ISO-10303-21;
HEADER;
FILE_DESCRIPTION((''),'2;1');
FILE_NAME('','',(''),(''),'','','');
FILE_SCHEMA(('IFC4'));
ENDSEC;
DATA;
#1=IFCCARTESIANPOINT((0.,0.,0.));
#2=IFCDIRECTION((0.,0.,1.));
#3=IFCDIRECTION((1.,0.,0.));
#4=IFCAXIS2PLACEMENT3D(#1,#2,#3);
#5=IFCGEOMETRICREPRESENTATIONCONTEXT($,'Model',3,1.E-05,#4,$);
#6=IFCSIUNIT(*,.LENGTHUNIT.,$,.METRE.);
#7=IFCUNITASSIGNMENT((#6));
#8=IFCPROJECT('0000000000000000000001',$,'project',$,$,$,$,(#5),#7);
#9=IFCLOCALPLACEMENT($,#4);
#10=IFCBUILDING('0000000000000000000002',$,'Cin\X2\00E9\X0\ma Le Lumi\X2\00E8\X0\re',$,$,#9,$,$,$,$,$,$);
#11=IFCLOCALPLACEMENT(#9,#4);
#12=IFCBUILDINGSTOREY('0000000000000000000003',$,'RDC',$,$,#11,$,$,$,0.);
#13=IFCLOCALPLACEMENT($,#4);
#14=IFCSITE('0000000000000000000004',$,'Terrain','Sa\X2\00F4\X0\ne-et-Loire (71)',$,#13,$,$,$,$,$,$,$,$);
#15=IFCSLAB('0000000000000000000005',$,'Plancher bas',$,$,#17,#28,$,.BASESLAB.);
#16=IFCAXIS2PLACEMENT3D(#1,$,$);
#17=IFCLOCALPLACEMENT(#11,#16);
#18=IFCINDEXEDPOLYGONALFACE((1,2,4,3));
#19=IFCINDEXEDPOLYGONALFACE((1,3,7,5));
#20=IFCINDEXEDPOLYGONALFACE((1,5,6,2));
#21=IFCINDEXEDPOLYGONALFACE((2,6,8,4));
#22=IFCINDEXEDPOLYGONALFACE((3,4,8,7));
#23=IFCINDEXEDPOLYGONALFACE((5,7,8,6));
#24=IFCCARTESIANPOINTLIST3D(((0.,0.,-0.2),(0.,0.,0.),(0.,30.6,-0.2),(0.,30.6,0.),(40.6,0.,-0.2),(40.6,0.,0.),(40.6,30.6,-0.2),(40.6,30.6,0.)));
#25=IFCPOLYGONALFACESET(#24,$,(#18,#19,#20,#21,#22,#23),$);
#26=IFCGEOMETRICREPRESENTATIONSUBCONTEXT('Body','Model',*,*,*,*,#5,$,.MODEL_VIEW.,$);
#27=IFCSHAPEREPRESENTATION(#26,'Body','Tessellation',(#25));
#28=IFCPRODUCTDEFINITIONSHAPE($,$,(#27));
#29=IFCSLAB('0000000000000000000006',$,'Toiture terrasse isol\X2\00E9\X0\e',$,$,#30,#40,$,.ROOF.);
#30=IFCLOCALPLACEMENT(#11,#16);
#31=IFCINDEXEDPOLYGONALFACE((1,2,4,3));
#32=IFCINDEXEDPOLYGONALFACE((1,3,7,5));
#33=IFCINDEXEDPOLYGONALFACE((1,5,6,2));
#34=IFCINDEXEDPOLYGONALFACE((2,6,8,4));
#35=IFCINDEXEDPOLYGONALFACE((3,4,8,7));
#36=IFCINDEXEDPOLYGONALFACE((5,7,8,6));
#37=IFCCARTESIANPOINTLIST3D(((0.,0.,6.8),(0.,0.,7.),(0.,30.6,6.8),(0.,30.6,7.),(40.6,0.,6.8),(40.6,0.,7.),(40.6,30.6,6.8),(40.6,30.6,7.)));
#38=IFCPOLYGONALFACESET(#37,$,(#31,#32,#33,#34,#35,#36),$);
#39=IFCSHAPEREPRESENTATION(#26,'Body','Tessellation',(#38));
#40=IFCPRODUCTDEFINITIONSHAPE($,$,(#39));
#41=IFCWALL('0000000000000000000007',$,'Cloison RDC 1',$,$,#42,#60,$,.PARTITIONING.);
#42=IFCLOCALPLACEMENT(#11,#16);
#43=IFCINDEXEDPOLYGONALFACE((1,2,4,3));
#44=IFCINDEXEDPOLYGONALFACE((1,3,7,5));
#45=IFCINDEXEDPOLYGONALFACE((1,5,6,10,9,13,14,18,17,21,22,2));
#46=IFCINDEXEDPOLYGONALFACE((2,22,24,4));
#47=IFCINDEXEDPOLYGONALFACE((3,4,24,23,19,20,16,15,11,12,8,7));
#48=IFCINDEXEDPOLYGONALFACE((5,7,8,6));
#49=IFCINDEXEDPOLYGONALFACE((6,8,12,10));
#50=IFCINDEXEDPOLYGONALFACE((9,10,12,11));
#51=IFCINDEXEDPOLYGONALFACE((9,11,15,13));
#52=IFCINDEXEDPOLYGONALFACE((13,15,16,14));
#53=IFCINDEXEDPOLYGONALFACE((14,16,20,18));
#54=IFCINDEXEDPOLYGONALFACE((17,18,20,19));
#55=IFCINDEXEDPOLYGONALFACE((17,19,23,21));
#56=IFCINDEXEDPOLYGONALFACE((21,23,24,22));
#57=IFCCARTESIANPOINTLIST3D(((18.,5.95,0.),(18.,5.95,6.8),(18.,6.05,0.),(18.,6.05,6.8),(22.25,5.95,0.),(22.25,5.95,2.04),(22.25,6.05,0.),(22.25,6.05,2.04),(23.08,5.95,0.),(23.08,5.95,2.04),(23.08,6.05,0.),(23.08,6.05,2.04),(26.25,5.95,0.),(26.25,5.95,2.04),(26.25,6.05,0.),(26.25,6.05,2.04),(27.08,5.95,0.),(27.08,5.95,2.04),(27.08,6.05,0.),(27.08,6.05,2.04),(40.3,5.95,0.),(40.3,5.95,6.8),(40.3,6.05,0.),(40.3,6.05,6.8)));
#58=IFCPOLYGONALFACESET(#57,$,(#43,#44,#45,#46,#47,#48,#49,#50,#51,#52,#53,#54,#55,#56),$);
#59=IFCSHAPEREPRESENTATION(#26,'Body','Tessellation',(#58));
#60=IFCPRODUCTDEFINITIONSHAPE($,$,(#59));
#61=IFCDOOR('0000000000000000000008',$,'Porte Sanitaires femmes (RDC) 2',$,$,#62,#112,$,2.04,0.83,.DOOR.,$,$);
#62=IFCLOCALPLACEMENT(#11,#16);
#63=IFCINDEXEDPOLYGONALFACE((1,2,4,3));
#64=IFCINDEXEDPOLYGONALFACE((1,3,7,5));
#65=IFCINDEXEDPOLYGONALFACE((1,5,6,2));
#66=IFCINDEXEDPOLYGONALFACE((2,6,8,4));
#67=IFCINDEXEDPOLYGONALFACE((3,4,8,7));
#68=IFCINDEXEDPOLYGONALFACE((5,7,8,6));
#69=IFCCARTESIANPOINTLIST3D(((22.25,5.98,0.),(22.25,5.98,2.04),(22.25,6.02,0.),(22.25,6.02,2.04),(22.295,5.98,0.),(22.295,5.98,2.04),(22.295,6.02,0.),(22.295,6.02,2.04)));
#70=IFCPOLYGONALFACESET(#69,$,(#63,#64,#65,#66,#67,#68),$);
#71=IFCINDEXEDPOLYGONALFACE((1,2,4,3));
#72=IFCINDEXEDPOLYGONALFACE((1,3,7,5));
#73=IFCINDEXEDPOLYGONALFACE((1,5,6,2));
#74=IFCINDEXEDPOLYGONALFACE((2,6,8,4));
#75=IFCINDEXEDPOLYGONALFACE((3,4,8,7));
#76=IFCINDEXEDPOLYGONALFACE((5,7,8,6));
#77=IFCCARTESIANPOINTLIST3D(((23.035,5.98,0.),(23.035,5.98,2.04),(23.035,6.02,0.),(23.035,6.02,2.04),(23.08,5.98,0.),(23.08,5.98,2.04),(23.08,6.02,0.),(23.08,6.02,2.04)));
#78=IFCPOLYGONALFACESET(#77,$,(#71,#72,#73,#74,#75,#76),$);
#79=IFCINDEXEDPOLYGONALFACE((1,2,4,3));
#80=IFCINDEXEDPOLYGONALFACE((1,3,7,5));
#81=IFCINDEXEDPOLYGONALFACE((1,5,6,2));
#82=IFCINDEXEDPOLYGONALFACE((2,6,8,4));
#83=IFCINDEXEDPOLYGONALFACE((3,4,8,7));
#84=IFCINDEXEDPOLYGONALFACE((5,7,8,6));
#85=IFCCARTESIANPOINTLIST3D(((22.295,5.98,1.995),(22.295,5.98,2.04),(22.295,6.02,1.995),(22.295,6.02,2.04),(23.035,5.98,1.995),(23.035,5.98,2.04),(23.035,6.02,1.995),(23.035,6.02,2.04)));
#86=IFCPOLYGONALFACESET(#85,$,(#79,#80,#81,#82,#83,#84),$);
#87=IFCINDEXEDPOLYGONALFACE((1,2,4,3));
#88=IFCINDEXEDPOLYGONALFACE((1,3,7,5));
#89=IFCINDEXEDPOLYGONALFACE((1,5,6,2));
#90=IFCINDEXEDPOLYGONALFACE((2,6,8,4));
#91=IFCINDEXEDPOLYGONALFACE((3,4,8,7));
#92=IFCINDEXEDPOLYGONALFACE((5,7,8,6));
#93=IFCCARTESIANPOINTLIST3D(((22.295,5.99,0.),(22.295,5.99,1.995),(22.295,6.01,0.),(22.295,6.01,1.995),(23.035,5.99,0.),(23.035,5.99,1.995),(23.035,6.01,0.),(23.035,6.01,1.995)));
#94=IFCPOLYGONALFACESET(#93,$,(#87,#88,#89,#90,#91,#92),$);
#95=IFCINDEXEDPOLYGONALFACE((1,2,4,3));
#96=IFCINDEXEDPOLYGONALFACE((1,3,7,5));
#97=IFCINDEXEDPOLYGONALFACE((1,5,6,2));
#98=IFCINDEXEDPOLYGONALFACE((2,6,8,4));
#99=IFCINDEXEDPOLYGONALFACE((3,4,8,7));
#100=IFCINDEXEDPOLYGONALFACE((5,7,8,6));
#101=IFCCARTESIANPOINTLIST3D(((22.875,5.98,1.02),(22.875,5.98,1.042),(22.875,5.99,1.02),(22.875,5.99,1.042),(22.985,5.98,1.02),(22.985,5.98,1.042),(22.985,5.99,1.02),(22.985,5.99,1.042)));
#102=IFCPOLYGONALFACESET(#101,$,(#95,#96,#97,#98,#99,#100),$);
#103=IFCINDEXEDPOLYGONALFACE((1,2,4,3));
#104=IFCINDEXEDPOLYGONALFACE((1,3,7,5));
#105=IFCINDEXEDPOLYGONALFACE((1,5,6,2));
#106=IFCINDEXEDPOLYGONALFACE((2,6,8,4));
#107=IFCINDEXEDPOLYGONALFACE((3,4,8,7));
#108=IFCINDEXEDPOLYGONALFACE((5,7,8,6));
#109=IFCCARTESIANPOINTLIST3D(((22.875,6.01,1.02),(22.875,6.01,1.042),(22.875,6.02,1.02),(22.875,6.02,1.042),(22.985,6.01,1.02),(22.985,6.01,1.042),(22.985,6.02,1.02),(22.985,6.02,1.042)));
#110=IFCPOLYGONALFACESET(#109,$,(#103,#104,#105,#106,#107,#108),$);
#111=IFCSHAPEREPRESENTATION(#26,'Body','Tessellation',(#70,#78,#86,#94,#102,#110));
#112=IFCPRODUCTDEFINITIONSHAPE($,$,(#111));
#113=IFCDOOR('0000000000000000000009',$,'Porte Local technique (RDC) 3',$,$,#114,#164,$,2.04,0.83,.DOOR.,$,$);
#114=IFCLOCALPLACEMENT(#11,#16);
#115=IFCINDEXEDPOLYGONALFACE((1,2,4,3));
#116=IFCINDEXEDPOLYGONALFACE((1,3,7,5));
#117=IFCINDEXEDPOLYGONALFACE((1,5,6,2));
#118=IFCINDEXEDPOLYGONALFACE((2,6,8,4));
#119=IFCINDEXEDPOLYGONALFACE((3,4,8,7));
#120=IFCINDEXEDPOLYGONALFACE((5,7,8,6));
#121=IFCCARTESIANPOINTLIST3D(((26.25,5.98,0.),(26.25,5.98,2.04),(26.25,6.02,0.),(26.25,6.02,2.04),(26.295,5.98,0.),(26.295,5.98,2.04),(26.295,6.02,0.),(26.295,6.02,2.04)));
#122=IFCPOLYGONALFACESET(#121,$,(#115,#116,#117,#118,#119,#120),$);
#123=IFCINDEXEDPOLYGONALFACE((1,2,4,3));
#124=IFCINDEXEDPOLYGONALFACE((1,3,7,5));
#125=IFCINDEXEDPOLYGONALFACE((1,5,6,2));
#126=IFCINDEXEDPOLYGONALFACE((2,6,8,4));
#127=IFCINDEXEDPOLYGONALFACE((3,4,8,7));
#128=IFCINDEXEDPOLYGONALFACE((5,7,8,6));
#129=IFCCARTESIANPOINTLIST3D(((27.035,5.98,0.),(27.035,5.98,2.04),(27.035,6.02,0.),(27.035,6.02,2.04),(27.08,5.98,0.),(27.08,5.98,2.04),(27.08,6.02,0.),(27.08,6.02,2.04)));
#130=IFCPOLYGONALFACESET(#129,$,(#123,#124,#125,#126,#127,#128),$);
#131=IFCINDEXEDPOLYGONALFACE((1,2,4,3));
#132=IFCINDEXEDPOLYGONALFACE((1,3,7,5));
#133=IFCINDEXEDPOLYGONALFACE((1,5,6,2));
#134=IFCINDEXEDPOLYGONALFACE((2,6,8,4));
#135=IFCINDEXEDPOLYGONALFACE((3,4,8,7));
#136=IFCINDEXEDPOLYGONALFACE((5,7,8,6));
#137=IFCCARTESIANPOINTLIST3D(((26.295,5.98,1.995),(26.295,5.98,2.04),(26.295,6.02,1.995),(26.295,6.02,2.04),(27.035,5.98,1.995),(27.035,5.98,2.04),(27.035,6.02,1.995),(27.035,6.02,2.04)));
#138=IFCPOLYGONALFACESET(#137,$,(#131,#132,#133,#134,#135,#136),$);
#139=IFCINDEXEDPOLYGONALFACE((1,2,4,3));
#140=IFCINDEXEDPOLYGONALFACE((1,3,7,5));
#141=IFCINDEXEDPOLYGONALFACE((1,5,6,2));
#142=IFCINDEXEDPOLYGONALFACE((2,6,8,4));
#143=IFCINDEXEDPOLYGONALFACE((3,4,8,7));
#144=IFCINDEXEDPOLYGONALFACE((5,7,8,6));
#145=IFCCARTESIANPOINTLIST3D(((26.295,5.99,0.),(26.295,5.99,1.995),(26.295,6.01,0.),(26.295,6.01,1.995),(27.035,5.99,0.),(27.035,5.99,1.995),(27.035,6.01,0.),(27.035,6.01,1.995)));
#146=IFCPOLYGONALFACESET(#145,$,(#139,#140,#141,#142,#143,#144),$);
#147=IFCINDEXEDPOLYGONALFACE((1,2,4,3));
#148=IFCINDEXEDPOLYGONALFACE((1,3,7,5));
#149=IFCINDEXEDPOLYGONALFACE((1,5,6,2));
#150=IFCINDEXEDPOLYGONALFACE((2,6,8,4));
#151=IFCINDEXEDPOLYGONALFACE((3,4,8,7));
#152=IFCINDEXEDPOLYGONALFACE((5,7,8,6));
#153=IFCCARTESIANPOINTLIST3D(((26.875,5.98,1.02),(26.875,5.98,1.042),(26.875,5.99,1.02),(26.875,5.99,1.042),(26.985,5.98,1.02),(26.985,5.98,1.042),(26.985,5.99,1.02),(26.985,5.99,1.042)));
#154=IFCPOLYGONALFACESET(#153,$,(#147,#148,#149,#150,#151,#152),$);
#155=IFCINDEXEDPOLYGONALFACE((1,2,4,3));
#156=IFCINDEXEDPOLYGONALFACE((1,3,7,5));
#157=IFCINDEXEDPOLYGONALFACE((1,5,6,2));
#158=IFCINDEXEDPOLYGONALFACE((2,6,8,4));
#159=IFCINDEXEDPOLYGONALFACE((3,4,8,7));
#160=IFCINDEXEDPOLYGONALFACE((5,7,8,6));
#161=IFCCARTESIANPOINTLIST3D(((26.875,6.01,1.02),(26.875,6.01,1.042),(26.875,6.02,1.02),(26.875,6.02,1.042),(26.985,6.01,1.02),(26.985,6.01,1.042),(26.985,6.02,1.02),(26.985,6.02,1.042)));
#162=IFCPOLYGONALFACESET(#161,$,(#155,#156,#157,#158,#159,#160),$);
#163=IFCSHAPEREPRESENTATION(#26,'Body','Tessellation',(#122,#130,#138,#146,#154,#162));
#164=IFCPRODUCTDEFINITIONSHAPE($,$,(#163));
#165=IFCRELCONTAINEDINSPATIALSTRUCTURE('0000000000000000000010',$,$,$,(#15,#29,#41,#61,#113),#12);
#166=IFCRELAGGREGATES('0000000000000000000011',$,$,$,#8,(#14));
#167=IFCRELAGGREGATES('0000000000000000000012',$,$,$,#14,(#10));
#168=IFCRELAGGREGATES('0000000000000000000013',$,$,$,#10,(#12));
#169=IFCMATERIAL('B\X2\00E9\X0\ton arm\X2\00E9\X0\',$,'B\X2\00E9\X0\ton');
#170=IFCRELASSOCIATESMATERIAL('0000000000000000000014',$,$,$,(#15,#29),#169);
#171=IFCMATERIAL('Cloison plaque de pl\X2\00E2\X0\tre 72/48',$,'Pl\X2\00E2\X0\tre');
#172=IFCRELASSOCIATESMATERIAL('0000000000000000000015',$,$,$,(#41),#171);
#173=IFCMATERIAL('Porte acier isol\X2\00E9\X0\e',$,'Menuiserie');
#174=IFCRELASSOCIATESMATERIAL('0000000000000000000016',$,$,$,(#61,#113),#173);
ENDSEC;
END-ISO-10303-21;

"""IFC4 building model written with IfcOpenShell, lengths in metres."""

from ifc_helpers import new_model, si_unit, frame, frame_2d, origin_with_axes, place, context, subcontext, project, spatial, rectangle, extrude, material, element, fill, save


model = new_model("IFC4")

# Units and contexts
model_context = context("Model", 3, precision=1e-05, world=origin_with_axes())
body_context = subcontext(model_context, "Body", "Model", "MODEL_VIEW")
ifc_project = project(units=[si_unit("LENGTHUNIT", "METRE")], contexts=[model_context])

# Site, building, storey
site_placement = place(None, origin_with_axes())
site = spatial("IfcSite", under=ifc_project, at=site_placement, Name="Terrain", Description="Saône-et-Loire (71)")
building_placement = place(None, origin_with_axes())
building = spatial("IfcBuilding", under=site, at=building_placement, Name="Cinéma Le Lumière")
storey_placement = place(building_placement, origin_with_axes())
storey = spatial("IfcBuildingStorey", under=building, at=storey_placement, Name="RDC", Elevation=0.0)

# Slabs
ifc_material_1 = material(Name="Béton armé", Category="Béton")
slab_1_placement = place(storey_placement, frame((0.0, 0.0, -0.2), z_axis=(0.0, 0.0, 1.0), x_axis=(1.0, 0.0, 0.0)))
element("IfcSlab", 1, at=slab_1_placement, inside=storey, material=ifc_material_1, Name="Plancher bas", PredefinedType="BASESLAB", context=body_context, shape_type="SweptSolid", body=[
    extrude(rectangle(XDim=40.6, YDim=30.6, at=frame_2d((20.3, 15.3))), origin_with_axes(), (0.0, 0.0, 1.0), 0.2),
])
slab_2_placement = place(storey_placement, frame((0.0, 0.0, 6.8), z_axis=(0.0, 0.0, 1.0), x_axis=(1.0, 0.0, 0.0)))
element("IfcSlab", 2, at=slab_2_placement, inside=storey, material=ifc_material_1, Name="Toiture terrasse isolée", PredefinedType="ROOF", context=body_context, shape_type="SweptSolid", body=[
    extrude(rectangle(XDim=40.6, YDim=30.6, at=frame_2d((20.3, 15.3))), origin_with_axes(), (0.0, 0.0, 1.0), 0.2),
])

# Shared definitions
ifc_material_2 = material(Name="Porte acier isolée", Category="Menuiserie")

# Wall, openings, doors
ifc_material_3 = material(Name="Cloison plaque de plâtre 72/48", Category="Plâtre")
wall_1_placement = place(storey_placement, frame((18.0, 5.95, 0.0), z_axis=(0.0, 0.0, 1.0), x_axis=(1.0, 0.0, 0.0)))
wall_1 = element("IfcWall", 3, at=wall_1_placement, inside=storey, material=ifc_material_3, Name="Cloison RDC 1", PredefinedType="PARTITIONING", context=body_context, shape_type="SweptSolid", body=[
    extrude(rectangle(XDim=22.3, YDim=0.1, at=frame_2d((11.15, 0.05))), origin_with_axes(), (0.0, 0.0, 1.0), 6.8),
])
opening_1_placement = place(storey_placement, frame((22.25, 5.9, 0.0), z_axis=(0.0, 0.0, 1.0), x_axis=(1.0, 0.0, 0.0)))
opening_1 = element("IfcOpeningElement", 4, at=opening_1_placement, cuts=wall_1, context=body_context, shape_type="SweptSolid", body=[
    extrude(rectangle(XDim=0.83, YDim=0.2, at=frame_2d((0.415, 0.1))), origin_with_axes(), (0.0, 0.0, 1.0), 2.04),
])
opening_2_placement = place(storey_placement, frame((26.25, 5.9, 0.0), z_axis=(0.0, 0.0, 1.0), x_axis=(1.0, 0.0, 0.0)))
opening_2 = element("IfcOpeningElement", 5, at=opening_2_placement, cuts=wall_1, context=body_context, shape_type="SweptSolid", body=[
    extrude(rectangle(XDim=0.83, YDim=0.2, at=frame_2d((0.415, 0.1))), origin_with_axes(), (0.0, 0.0, 1.0), 2.04),
])
door_1_placement = place(storey_placement, frame((22.25, 5.98, 0.0), z_axis=(0.0, 0.0, 1.0), x_axis=(1.0, 0.0, 0.0)))
door_1 = element("IfcDoor", 6, at=door_1_placement, inside=storey, material=ifc_material_2, Name="Porte Sanitaires femmes (RDC) 2", OverallHeight=2.04, OverallWidth=0.83, PredefinedType="DOOR", context=body_context, shape_type="SweptSolid", body=[
    extrude(rectangle(XDim=0.045, YDim=0.04, at=frame_2d((0.0225, 0.02))), origin_with_axes(), (0.0, 0.0, 1.0), 2.04),
    extrude(rectangle(XDim=0.045, YDim=0.04, at=frame_2d((0.0225, 0.02))), frame((0.785, 0.0, 0.0), z_axis=(0.0, 0.0, 1.0), x_axis=(1.0, 0.0, 0.0)), (0.0, 0.0, 1.0), 2.04),
    extrude(rectangle(XDim=0.74, YDim=0.04, at=frame_2d((0.37, 0.02))), frame((0.045, 0.0, 1.995), z_axis=(0.0, 0.0, 1.0), x_axis=(1.0, 0.0, 0.0)), (0.0, 0.0, 1.0), 0.045),
    extrude(rectangle(XDim=0.74, YDim=0.02, at=frame_2d((0.37, 0.01))), frame((0.045, 0.01, 0.0), z_axis=(0.0, 0.0, 1.0), x_axis=(1.0, 0.0, 0.0)), (0.0, 0.0, 1.0), 1.995),
    extrude(rectangle(XDim=0.11, YDim=0.01, at=frame_2d((0.055, 0.005))), frame((0.625, 0.0, 1.02), z_axis=(0.0, 0.0, 1.0), x_axis=(1.0, 0.0, 0.0)), (0.0, 0.0, 1.0), 0.022),
    extrude(rectangle(XDim=0.11, YDim=0.01, at=frame_2d((0.055, 0.005))), frame((0.625, 0.03, 1.02), z_axis=(0.0, 0.0, 1.0), x_axis=(1.0, 0.0, 0.0)), (0.0, 0.0, 1.0), 0.022),
])
fill(opening_1, door_1)
door_2_placement = place(storey_placement, frame((26.25, 5.98, 0.0), z_axis=(0.0, 0.0, 1.0), x_axis=(1.0, 0.0, 0.0)))
door_2 = element("IfcDoor", 7, at=door_2_placement, inside=storey, material=ifc_material_2, Name="Porte Local technique (RDC) 3", OverallHeight=2.04, OverallWidth=0.83, PredefinedType="DOOR", context=body_context, shape_type="SweptSolid", body=[
    extrude(rectangle(XDim=0.045, YDim=0.04, at=frame_2d((0.0225, 0.02))), origin_with_axes(), (0.0, 0.0, 1.0), 2.04),
    extrude(rectangle(XDim=0.045, YDim=0.04, at=frame_2d((0.0225, 0.02))), frame((0.785, 0.0, 0.0), z_axis=(0.0, 0.0, 1.0), x_axis=(1.0, 0.0, 0.0)), (0.0, 0.0, 1.0), 2.04),
    extrude(rectangle(XDim=0.74, YDim=0.04, at=frame_2d((0.37, 0.02))), frame((0.045, 0.0, 1.995), z_axis=(0.0, 0.0, 1.0), x_axis=(1.0, 0.0, 0.0)), (0.0, 0.0, 1.0), 0.045),
    extrude(rectangle(XDim=0.74, YDim=0.02, at=frame_2d((0.37, 0.01))), frame((0.045, 0.01, 0.0), z_axis=(0.0, 0.0, 1.0), x_axis=(1.0, 0.0, 0.0)), (0.0, 0.0, 1.0), 1.995),
    extrude(rectangle(XDim=0.11, YDim=0.01, at=frame_2d((0.055, 0.005))), frame((0.625, 0.0, 1.02), z_axis=(0.0, 0.0, 1.0), x_axis=(1.0, 0.0, 0.0)), (0.0, 0.0, 1.0), 0.022),
    extrude(rectangle(XDim=0.11, YDim=0.01, at=frame_2d((0.055, 0.005))), frame((0.625, 0.03, 1.02), z_axis=(0.0, 0.0, 1.0), x_axis=(1.0, 0.0, 0.0)), (0.0, 0.0, 1.0), 0.022),
])
fill(opening_2, door_2)

save(model, "model.ifc")
